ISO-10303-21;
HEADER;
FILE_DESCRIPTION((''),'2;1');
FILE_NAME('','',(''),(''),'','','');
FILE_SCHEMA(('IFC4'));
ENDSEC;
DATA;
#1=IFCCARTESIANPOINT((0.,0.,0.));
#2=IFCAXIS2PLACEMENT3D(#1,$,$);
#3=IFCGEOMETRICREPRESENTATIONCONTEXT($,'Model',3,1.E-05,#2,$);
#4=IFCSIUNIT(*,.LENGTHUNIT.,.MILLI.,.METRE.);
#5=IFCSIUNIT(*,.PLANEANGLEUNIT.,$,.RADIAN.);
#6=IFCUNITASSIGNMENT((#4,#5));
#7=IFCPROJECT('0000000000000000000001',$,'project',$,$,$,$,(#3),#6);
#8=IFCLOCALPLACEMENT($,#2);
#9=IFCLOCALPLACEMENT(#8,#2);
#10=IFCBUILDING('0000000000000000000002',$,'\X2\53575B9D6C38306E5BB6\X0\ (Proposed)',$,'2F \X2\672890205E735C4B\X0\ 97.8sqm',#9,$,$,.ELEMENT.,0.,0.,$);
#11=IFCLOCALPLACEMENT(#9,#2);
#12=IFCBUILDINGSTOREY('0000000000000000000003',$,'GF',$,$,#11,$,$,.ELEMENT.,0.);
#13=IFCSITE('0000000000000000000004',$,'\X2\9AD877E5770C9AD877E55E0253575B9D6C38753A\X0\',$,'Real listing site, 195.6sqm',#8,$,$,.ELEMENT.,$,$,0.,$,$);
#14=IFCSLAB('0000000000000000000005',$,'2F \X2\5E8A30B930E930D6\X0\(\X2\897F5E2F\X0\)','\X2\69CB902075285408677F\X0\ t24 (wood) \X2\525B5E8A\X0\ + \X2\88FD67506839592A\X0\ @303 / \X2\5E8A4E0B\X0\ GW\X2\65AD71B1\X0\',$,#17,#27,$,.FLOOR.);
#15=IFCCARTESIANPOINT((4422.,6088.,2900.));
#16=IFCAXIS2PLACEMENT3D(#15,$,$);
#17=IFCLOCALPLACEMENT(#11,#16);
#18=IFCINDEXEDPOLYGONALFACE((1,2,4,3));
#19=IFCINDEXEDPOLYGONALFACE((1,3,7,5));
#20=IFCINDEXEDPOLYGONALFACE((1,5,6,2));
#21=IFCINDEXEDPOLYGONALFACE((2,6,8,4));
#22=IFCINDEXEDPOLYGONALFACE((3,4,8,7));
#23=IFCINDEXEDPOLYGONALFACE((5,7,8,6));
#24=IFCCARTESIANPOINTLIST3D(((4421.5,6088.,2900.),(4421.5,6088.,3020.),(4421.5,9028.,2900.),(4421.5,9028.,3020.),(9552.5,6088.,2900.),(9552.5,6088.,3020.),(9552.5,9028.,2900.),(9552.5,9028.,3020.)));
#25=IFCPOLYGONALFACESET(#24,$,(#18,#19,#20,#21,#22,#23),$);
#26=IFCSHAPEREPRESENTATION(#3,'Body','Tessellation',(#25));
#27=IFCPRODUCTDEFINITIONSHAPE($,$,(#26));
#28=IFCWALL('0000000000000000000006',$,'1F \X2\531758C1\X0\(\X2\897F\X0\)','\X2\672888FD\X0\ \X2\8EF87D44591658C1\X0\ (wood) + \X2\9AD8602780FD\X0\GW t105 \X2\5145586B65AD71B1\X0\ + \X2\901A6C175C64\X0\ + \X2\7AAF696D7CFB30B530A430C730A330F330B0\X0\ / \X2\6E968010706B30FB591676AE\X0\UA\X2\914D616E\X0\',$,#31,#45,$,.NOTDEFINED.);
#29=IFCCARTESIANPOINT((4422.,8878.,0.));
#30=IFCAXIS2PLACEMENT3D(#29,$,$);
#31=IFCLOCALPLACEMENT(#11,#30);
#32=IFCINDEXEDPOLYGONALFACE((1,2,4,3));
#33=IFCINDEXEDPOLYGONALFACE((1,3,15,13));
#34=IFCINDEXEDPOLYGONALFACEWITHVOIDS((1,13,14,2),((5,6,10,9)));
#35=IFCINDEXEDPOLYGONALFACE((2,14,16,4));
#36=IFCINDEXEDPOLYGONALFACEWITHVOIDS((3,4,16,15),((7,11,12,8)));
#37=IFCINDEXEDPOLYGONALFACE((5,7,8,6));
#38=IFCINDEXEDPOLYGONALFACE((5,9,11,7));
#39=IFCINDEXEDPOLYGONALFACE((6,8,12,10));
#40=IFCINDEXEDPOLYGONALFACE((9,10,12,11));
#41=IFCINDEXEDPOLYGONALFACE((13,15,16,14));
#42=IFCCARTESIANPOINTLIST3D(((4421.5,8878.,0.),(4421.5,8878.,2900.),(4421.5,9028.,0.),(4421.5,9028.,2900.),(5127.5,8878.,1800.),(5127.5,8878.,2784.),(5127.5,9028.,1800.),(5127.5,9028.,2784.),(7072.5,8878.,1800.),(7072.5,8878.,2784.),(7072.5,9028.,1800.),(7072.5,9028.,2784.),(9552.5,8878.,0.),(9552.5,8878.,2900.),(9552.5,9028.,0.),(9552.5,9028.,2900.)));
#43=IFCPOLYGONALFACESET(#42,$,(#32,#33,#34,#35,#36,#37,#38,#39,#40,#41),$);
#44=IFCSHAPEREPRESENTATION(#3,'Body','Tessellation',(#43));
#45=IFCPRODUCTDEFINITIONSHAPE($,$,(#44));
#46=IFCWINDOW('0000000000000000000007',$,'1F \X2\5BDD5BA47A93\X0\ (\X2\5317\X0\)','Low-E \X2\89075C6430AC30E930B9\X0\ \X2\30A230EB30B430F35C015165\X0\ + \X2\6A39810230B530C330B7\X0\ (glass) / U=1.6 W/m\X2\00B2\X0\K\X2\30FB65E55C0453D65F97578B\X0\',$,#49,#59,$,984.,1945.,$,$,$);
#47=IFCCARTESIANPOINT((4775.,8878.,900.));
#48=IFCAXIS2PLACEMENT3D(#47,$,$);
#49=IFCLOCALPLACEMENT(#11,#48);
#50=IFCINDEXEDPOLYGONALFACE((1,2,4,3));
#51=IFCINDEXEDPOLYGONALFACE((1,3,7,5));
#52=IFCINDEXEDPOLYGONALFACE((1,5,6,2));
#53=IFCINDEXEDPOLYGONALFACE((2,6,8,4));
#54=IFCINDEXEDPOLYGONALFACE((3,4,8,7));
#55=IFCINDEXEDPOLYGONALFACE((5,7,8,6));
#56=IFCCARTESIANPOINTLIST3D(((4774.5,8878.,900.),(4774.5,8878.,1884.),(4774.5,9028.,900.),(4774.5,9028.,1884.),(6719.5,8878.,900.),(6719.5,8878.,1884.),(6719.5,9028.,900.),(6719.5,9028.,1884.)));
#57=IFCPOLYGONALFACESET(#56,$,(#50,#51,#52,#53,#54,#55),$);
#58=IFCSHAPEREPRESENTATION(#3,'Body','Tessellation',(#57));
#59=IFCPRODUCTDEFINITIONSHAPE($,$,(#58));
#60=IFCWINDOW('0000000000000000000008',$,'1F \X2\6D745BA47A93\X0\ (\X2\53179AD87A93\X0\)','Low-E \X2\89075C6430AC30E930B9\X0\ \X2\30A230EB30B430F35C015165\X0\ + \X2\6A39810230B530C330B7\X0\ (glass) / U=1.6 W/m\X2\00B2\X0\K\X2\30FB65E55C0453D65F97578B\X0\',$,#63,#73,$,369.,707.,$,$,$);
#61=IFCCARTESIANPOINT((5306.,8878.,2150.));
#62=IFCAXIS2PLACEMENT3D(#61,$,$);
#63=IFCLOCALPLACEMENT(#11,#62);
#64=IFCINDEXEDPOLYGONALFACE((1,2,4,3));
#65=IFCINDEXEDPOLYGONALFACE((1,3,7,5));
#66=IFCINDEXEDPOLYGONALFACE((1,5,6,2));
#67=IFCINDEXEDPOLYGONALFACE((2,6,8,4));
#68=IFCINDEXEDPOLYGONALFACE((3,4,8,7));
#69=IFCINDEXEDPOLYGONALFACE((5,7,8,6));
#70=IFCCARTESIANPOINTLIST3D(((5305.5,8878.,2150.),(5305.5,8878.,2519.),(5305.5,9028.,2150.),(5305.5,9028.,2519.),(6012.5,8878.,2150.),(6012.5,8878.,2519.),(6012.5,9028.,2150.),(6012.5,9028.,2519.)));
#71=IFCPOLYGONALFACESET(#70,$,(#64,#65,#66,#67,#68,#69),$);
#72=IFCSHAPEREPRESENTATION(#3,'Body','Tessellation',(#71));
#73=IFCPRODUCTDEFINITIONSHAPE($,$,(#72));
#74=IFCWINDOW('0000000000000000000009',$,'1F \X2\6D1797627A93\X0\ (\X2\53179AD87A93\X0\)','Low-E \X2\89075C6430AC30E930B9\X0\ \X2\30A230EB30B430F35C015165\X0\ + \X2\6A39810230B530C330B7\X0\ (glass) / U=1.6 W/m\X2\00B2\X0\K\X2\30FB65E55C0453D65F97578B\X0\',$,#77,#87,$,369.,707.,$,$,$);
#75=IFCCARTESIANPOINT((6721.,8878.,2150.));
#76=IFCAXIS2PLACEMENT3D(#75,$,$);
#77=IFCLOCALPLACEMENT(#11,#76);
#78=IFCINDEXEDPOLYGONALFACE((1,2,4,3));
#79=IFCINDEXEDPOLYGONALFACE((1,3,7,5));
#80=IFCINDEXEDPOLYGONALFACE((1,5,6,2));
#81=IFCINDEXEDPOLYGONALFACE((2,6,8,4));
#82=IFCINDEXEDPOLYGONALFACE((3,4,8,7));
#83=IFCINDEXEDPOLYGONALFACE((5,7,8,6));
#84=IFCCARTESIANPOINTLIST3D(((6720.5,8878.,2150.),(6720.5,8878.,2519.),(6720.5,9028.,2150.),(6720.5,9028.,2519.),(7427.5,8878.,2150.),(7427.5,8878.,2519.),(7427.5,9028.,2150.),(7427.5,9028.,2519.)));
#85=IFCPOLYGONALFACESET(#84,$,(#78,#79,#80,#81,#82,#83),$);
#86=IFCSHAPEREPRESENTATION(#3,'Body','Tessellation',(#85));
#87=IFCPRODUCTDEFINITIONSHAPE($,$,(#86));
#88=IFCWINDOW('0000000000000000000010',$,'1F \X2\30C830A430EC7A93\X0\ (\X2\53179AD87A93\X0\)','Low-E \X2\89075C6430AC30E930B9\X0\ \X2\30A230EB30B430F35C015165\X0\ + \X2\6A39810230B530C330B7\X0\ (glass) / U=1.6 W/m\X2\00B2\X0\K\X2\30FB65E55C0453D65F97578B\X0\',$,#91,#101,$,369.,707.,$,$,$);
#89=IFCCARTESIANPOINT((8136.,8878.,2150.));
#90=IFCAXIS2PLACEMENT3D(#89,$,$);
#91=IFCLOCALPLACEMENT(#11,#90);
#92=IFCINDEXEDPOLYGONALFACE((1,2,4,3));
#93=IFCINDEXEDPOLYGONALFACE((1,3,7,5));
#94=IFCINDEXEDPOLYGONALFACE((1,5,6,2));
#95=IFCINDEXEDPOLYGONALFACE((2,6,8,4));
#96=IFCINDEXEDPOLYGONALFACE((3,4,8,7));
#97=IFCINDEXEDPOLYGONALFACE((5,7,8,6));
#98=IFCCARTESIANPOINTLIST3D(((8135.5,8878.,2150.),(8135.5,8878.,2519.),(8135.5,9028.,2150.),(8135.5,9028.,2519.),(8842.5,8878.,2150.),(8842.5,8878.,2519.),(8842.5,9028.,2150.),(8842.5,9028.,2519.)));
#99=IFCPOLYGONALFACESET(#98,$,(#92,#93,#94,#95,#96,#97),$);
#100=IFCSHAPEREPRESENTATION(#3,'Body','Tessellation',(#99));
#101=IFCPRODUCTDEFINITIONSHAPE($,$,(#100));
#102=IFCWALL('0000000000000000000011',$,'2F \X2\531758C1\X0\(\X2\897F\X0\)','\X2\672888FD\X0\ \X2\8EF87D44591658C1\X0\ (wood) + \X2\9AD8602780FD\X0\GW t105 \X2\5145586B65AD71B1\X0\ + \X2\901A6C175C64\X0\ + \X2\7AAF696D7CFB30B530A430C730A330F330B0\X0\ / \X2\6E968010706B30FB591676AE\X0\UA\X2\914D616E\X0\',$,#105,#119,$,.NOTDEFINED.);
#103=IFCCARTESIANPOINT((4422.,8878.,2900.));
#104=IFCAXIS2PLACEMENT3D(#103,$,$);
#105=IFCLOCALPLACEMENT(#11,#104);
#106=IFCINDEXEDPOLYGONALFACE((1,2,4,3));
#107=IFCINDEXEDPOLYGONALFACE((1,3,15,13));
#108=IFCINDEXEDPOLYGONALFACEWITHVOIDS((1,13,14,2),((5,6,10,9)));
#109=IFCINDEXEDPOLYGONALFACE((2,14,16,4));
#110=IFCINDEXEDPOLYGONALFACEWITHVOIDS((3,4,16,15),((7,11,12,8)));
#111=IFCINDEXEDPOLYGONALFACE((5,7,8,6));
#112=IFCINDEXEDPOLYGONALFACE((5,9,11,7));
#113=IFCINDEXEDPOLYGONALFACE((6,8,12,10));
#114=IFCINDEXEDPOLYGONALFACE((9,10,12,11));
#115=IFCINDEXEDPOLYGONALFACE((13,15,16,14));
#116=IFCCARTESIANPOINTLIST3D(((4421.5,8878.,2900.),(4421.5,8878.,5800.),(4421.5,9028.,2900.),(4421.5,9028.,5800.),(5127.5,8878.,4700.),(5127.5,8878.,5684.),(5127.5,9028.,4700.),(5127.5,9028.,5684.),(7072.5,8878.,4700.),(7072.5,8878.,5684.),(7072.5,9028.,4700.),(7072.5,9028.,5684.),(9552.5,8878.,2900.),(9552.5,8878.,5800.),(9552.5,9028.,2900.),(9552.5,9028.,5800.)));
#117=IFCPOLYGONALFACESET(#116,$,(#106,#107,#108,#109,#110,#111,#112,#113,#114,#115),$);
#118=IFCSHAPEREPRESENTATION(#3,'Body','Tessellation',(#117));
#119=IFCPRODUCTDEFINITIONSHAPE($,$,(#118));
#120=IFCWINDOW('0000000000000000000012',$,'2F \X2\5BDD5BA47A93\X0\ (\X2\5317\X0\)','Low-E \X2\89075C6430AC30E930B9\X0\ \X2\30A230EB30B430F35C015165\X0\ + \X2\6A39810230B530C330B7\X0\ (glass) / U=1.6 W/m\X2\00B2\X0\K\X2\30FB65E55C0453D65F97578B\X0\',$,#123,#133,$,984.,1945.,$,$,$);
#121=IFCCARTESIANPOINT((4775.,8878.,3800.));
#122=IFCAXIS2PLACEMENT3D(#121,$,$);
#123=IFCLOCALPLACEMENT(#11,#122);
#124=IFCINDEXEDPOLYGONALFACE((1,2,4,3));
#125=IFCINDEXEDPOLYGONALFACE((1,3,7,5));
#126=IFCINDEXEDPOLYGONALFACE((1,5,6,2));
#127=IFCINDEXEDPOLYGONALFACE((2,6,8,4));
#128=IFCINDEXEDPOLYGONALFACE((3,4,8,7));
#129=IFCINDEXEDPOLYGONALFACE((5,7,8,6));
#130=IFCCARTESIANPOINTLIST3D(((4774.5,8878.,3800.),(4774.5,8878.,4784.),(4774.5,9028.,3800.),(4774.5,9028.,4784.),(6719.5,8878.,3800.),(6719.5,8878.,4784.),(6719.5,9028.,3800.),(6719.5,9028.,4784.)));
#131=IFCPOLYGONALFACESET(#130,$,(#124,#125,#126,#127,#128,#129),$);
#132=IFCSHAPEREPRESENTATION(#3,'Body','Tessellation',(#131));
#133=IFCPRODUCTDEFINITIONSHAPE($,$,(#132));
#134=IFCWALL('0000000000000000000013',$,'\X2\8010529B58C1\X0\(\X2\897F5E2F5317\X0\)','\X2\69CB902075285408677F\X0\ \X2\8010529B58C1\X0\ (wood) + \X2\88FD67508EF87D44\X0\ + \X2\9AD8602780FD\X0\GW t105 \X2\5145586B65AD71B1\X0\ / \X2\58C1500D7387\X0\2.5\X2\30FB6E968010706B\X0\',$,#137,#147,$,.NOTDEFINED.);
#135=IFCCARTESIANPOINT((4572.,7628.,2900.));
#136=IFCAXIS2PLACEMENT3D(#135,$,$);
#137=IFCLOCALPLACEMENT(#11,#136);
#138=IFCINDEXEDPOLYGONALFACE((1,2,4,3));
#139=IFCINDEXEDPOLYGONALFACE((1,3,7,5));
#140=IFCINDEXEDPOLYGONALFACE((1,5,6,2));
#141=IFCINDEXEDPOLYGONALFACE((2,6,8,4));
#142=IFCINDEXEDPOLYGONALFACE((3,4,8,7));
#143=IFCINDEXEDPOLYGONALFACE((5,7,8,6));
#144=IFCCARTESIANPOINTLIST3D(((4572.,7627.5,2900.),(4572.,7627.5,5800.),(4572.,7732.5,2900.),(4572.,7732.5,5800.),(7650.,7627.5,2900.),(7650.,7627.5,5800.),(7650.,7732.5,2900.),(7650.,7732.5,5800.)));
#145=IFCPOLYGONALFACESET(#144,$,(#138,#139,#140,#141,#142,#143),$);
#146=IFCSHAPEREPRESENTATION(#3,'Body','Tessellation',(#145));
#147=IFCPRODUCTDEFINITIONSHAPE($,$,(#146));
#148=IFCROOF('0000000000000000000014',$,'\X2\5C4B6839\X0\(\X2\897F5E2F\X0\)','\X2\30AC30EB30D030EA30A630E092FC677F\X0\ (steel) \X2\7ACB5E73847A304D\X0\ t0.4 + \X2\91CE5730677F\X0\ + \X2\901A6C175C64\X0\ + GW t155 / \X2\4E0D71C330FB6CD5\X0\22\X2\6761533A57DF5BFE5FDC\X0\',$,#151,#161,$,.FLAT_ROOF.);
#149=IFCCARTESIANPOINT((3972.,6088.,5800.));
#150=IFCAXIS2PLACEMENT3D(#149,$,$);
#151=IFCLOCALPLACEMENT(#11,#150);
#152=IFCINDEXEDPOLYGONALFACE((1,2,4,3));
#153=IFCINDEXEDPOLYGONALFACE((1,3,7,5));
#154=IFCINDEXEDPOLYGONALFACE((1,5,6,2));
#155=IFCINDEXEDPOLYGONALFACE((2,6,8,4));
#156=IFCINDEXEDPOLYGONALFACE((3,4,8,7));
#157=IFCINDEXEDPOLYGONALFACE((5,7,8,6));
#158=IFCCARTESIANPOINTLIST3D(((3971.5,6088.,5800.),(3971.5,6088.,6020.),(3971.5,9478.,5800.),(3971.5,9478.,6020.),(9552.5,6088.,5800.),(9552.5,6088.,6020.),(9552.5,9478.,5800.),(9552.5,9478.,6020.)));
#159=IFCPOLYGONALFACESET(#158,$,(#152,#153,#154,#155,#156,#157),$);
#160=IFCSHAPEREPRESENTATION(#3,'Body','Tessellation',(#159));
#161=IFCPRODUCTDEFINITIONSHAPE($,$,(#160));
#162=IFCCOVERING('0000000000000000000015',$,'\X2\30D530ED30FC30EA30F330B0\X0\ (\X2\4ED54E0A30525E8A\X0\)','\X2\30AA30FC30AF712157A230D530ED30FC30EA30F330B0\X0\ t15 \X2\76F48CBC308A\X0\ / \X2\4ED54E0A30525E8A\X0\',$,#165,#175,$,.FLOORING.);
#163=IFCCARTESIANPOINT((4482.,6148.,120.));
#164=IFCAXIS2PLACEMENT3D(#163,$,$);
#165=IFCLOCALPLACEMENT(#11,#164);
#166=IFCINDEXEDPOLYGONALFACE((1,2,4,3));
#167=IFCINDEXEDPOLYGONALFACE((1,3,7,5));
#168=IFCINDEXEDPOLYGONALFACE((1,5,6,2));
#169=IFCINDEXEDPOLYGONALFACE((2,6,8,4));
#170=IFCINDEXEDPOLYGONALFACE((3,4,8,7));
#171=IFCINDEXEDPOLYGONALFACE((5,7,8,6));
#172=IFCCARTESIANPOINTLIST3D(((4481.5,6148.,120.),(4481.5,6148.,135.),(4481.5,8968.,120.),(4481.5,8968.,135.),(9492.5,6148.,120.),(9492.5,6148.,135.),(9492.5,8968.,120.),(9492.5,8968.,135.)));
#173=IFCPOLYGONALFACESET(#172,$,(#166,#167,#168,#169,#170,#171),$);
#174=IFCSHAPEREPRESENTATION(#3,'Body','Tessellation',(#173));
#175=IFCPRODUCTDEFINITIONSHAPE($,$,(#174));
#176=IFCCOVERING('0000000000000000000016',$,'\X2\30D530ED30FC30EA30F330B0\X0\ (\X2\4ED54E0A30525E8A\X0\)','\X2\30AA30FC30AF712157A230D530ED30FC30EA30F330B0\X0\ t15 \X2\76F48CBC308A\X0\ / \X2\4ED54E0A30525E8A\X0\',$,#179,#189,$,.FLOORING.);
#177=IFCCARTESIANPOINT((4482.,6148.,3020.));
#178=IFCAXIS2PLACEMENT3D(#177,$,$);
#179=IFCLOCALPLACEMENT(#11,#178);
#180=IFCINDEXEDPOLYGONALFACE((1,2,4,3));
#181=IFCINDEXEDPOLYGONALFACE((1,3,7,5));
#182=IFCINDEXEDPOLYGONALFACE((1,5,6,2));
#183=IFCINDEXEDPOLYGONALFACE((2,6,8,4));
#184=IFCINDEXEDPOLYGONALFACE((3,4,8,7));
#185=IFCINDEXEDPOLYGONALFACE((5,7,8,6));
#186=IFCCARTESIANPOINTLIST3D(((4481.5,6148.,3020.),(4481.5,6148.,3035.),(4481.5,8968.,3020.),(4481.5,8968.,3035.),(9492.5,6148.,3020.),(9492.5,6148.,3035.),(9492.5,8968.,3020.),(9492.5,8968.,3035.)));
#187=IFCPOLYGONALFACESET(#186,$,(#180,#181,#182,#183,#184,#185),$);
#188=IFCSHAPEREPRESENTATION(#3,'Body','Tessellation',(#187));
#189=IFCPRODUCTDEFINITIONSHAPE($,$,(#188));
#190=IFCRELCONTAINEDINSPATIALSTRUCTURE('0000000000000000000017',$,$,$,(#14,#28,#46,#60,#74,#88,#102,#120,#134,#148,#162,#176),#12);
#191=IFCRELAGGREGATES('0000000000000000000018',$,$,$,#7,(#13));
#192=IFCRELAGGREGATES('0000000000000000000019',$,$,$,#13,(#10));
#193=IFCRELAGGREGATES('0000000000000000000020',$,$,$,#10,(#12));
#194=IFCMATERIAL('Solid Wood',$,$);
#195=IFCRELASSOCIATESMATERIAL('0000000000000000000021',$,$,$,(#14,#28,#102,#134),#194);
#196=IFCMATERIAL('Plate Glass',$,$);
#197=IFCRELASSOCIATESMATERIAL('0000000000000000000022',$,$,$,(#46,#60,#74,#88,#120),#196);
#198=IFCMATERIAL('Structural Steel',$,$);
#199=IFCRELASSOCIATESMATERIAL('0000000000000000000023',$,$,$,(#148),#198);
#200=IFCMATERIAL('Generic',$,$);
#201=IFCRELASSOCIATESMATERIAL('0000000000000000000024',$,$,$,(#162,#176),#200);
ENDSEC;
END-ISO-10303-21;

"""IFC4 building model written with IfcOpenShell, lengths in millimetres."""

from ifc_helpers import new_model, si_unit, frame, frame_2d, origin, place, context, project, spatial, rectangle, extrude, material, element, fill, save


model = new_model("IFC4")

# Units and contexts
model_context = context("Model", 3, precision=1e-05, world=origin())
ifc_project = project(units=[si_unit("LENGTHUNIT", "METRE", prefix="MILLI"), si_unit("PLANEANGLEUNIT", "RADIAN")], contexts=[model_context])

# Site, building, storey
site_placement = place(None, origin())
site = spatial("IfcSite", under=ifc_project, at=site_placement, Name="高知県高知市南宝永町", ObjectType="Real listing site, 195.6sqm", CompositionType="ELEMENT", RefElevation=0.0)
building_placement = place(site_placement, origin())
building = spatial("IfcBuilding", under=site, at=building_placement, Name="南宝永の家 (Proposed)", ObjectType="2F 木造平屋 97.8sqm", CompositionType="ELEMENT", ElevationOfRefHeight=0.0, ElevationOfTerrain=0.0)
storey_placement = place(building_placement, origin())
storey = spatial("IfcBuildingStorey", under=building, at=storey_placement, Name="GF", CompositionType="ELEMENT", Elevation=0.0)

# Slab
ifc_material_1 = material(Name="Solid Wood")
slab_1_placement = place(storey_placement, frame((4422.0, 6088.0, 2900.0)))
element("IfcSlab", 1, at=slab_1_placement, inside=storey, material=ifc_material_1, Name="2F 床スラブ(西帯)", Description="構造用合板 t24 (wood) 剛床 + 製材根太 @303 / 床下 GW断熱", PredefinedType="FLOOR", context=model_context, shape_type="SweptSolid", body=[
    extrude(rectangle(XDim=5131.0, YDim=2940.0, at=frame_2d((2565.0, 1470.0))), frame((4422.0, 6088.0, 2900.0)), (0.0, 0.0, 1.0), 120.0),
])

# Wall, openings, windows
wall_1_placement = place(storey_placement, frame((4422.0, 8878.0, 0.0)))
wall_1 = element("IfcWall", 2, at=wall_1_placement, inside=storey, material=ifc_material_1, Name="1F 北壁(西)", Description="木製 軸組外壁 (wood) + 高性能GW t105 充填断熱 + 通気層 + 窯業系サイディング / 準耐火・外皮UA配慮", PredefinedType="NOTDEFINED", context=model_context, shape_type="SweptSolid", body=[
    extrude(rectangle(XDim=5131.0, YDim=150.0, at=frame_2d((2565.0, 75.0))), frame((4422.0, 8878.0, 0.0)), (0.0, 0.0, 1.0), 2900.0),
])
opening_1_placement = place(storey_placement, frame((4775.0, 8878.0, 900.0)))
opening_1 = element("IfcOpeningElement", 3, at=opening_1_placement, cuts=wall_1, PredefinedType="NOTDEFINED", context=model_context, shape_type="SweptSolid", body=[
    extrude(rectangle(XDim=1945.0, YDim=150.0, at=frame_2d((972.0, 75.0))), frame((4775.0, 8878.0, 900.0)), (0.0, 0.0, 1.0), 984.0),
])
opening_2_placement = place(storey_placement, frame((5306.0, 8878.0, 2150.0)))
opening_2 = element("IfcOpeningElement", 4, at=opening_2_placement, cuts=wall_1, PredefinedType="NOTDEFINED", context=model_context, shape_type="SweptSolid", body=[
    extrude(rectangle(XDim=707.0, YDim=150.0, at=frame_2d((353.0, 75.0))), frame((5306.0, 8878.0, 2150.0)), (0.0, 0.0, 1.0), 369.0),
])
opening_3_placement = place(storey_placement, frame((6721.0, 8878.0, 2150.0)))
opening_3 = element("IfcOpeningElement", 5, at=opening_3_placement, cuts=wall_1, PredefinedType="NOTDEFINED", context=model_context, shape_type="SweptSolid", body=[
    extrude(rectangle(XDim=707.0, YDim=150.0, at=frame_2d((353.0, 75.0))), frame((6721.0, 8878.0, 2150.0)), (0.0, 0.0, 1.0), 369.0),
])
opening_4_placement = place(storey_placement, frame((8136.0, 8878.0, 2150.0)))
opening_4 = element("IfcOpeningElement", 6, at=opening_4_placement, cuts=wall_1, PredefinedType="NOTDEFINED", context=model_context, shape_type="SweptSolid", body=[
    extrude(rectangle(XDim=707.0, YDim=150.0, at=frame_2d((353.0, 75.0))), frame((8136.0, 8878.0, 2150.0)), (0.0, 0.0, 1.0), 369.0),
])
ifc_material_2 = material(Name="Plate Glass")
window_1_placement = place(storey_placement, frame((4775.0, 8878.0, 900.0)))
window_1 = element("IfcWindow", 7, at=window_1_placement, inside=storey, material=ifc_material_2, Name="1F 寝室窓 (北)", Description="Low-E 複層ガラス アルゴン封入 + 樹脂サッシ (glass) / U=1.6 W/m²K・日射取得型", OverallHeight=984.0, OverallWidth=1945.0, context=model_context, shape_type="SweptSolid", body=[
    extrude(rectangle(XDim=1945.0, YDim=150.0, at=frame_2d((972.0, 75.0))), frame((4775.0, 8878.0, 900.0)), (0.0, 0.0, 1.0), 984.0),
])
fill(opening_1, window_1)
window_2_placement = place(storey_placement, frame((5306.0, 8878.0, 2150.0)))
window_2 = element("IfcWindow", 8, at=window_2_placement, inside=storey, material=ifc_material_2, Name="1F 浴室窓 (北高窓)", Description="Low-E 複層ガラス アルゴン封入 + 樹脂サッシ (glass) / U=1.6 W/m²K・日射取得型", OverallHeight=369.0, OverallWidth=707.0, context=model_context, shape_type="SweptSolid", body=[
    extrude(rectangle(XDim=707.0, YDim=150.0, at=frame_2d((353.0, 75.0))), frame((5306.0, 8878.0, 2150.0)), (0.0, 0.0, 1.0), 369.0),
])
fill(opening_2, window_2)
window_3_placement = place(storey_placement, frame((6721.0, 8878.0, 2150.0)))
window_3 = element("IfcWindow", 9, at=window_3_placement, inside=storey, material=ifc_material_2, Name="1F 洗面窓 (北高窓)", Description="Low-E 複層ガラス アルゴン封入 + 樹脂サッシ (glass) / U=1.6 W/m²K・日射取得型", OverallHeight=369.0, OverallWidth=707.0, context=model_context, shape_type="SweptSolid", body=[
    extrude(rectangle(XDim=707.0, YDim=150.0, at=frame_2d((353.0, 75.0))), frame((6721.0, 8878.0, 2150.0)), (0.0, 0.0, 1.0), 369.0),
])
fill(opening_3, window_3)
window_4_placement = place(storey_placement, frame((8136.0, 8878.0, 2150.0)))
window_4 = element("IfcWindow", 10, at=window_4_placement, inside=storey, material=ifc_material_2, Name="1F トイレ窓 (北高窓)", Description="Low-E 複層ガラス アルゴン封入 + 樹脂サッシ (glass) / U=1.6 W/m²K・日射取得型", OverallHeight=369.0, OverallWidth=707.0, context=model_context, shape_type="SweptSolid", body=[
    extrude(rectangle(XDim=707.0, YDim=150.0, at=frame_2d((353.0, 75.0))), frame((8136.0, 8878.0, 2150.0)), (0.0, 0.0, 1.0), 369.0),
])
fill(opening_4, window_4)

# Wall, opening, window
wall_2_placement = place(storey_placement, frame((4422.0, 8878.0, 2900.0)))
wall_2 = element("IfcWall", 11, at=wall_2_placement, inside=storey, material=ifc_material_1, Name="2F 北壁(西)", Description="木製 軸組外壁 (wood) + 高性能GW t105 充填断熱 + 通気層 + 窯業系サイディング / 準耐火・外皮UA配慮", PredefinedType="NOTDEFINED", context=model_context, shape_type="SweptSolid", body=[
    extrude(rectangle(XDim=5131.0, YDim=150.0, at=frame_2d((2565.0, 75.0))), frame((4422.0, 8878.0, 2900.0)), (0.0, 0.0, 1.0), 2900.0),
])
opening_5_placement = place(storey_placement, frame((4775.0, 8878.0, 3800.0)))
opening_5 = element("IfcOpeningElement", 12, at=opening_5_placement, cuts=wall_2, PredefinedType="NOTDEFINED", context=model_context, shape_type="SweptSolid", body=[
    extrude(rectangle(XDim=1945.0, YDim=150.0, at=frame_2d((972.0, 75.0))), frame((4775.0, 8878.0, 3800.0)), (0.0, 0.0, 1.0), 984.0),
])
window_5_placement = place(storey_placement, frame((4775.0, 8878.0, 3800.0)))
window_5 = element("IfcWindow", 13, at=window_5_placement, inside=storey, material=ifc_material_2, Name="2F 寝室窓 (北)", Description="Low-E 複層ガラス アルゴン封入 + 樹脂サッシ (glass) / U=1.6 W/m²K・日射取得型", OverallHeight=984.0, OverallWidth=1945.0, context=model_context, shape_type="SweptSolid", body=[
    extrude(rectangle(XDim=1945.0, YDim=150.0, at=frame_2d((972.0, 75.0))), frame((4775.0, 8878.0, 3800.0)), (0.0, 0.0, 1.0), 984.0),
])
fill(opening_5, window_5)

# Wall
wall_3_placement = place(storey_placement, frame((4572.0, 7628.0, 2900.0)))
element("IfcWall", 14, at=wall_3_placement, inside=storey, material=ifc_material_1, Name="耐力壁(西帯北)", Description="構造用合板 耐力壁 (wood) + 製材軸組 + 高性能GW t105 充填断熱 / 壁倍率2.5・準耐火", PredefinedType="NOTDEFINED", context=model_context, shape_type="SweptSolid", body=[
    extrude(rectangle(XDim=3078.0, YDim=105.0, at=frame_2d((1539.0, 52.0))), frame((4572.0, 7628.0, 2900.0)), (0.0, 0.0, 1.0), 2900.0),
])

# Roof
ifc_material_3 = material(Name="Structural Steel")
for number, where, name in (
    (15, (3972.0, 6088.0, 5800.0), "屋根(西帯)"),
):
    element("IfcRoof", number, at=place(storey_placement, frame(where)), inside=storey, material=ifc_material_3, Name=name, Description="ガルバリウム鋼板 (steel) 立平葺き t0.4 + 野地板 + 通気層 + GW t155 / 不燃・法22条区域対応", PredefinedType="FLAT_ROOF", context=model_context, shape_type="SweptSolid", body=[
        extrude(rectangle(XDim=5581.0, YDim=3390.0, at=frame_2d((2790.0, 1695.0))), frame((3972.0, 6088.0, 5800.0)), (0.0, 0.0, 1.0), 220.0),
    ])

# Coverings
ifc_material_4 = material(Name="Generic")
covering_1_placement = place(storey_placement, frame((4482.0, 6148.0, 120.0)))
element("IfcCovering", 16, at=covering_1_placement, inside=storey, material=ifc_material_4, Name="フローリング (仕上げ床)", Description="オーク無垢フローリング t15 直貼り / 仕上げ床", PredefinedType="FLOORING", context=model_context, shape_type="SweptSolid", body=[
    extrude(rectangle(XDim=5011.0, YDim=2820.0, at=frame_2d((2505.0, 1410.0))), frame((4482.0, 6148.0, 120.0)), (0.0, 0.0, 1.0), 15.0),
])
covering_2_placement = place(storey_placement, frame((4482.0, 6148.0, 3020.0)))
element("IfcCovering", 17, at=covering_2_placement, inside=storey, material=ifc_material_4, Name="フローリング (仕上げ床)", Description="オーク無垢フローリング t15 直貼り / 仕上げ床", PredefinedType="FLOORING", context=model_context, shape_type="SweptSolid", body=[
    extrude(rectangle(XDim=5011.0, YDim=2820.0, at=frame_2d((2505.0, 1410.0))), frame((4482.0, 6148.0, 3020.0)), (0.0, 0.0, 1.0), 15.0),
])

save(model, "model.ifc")
